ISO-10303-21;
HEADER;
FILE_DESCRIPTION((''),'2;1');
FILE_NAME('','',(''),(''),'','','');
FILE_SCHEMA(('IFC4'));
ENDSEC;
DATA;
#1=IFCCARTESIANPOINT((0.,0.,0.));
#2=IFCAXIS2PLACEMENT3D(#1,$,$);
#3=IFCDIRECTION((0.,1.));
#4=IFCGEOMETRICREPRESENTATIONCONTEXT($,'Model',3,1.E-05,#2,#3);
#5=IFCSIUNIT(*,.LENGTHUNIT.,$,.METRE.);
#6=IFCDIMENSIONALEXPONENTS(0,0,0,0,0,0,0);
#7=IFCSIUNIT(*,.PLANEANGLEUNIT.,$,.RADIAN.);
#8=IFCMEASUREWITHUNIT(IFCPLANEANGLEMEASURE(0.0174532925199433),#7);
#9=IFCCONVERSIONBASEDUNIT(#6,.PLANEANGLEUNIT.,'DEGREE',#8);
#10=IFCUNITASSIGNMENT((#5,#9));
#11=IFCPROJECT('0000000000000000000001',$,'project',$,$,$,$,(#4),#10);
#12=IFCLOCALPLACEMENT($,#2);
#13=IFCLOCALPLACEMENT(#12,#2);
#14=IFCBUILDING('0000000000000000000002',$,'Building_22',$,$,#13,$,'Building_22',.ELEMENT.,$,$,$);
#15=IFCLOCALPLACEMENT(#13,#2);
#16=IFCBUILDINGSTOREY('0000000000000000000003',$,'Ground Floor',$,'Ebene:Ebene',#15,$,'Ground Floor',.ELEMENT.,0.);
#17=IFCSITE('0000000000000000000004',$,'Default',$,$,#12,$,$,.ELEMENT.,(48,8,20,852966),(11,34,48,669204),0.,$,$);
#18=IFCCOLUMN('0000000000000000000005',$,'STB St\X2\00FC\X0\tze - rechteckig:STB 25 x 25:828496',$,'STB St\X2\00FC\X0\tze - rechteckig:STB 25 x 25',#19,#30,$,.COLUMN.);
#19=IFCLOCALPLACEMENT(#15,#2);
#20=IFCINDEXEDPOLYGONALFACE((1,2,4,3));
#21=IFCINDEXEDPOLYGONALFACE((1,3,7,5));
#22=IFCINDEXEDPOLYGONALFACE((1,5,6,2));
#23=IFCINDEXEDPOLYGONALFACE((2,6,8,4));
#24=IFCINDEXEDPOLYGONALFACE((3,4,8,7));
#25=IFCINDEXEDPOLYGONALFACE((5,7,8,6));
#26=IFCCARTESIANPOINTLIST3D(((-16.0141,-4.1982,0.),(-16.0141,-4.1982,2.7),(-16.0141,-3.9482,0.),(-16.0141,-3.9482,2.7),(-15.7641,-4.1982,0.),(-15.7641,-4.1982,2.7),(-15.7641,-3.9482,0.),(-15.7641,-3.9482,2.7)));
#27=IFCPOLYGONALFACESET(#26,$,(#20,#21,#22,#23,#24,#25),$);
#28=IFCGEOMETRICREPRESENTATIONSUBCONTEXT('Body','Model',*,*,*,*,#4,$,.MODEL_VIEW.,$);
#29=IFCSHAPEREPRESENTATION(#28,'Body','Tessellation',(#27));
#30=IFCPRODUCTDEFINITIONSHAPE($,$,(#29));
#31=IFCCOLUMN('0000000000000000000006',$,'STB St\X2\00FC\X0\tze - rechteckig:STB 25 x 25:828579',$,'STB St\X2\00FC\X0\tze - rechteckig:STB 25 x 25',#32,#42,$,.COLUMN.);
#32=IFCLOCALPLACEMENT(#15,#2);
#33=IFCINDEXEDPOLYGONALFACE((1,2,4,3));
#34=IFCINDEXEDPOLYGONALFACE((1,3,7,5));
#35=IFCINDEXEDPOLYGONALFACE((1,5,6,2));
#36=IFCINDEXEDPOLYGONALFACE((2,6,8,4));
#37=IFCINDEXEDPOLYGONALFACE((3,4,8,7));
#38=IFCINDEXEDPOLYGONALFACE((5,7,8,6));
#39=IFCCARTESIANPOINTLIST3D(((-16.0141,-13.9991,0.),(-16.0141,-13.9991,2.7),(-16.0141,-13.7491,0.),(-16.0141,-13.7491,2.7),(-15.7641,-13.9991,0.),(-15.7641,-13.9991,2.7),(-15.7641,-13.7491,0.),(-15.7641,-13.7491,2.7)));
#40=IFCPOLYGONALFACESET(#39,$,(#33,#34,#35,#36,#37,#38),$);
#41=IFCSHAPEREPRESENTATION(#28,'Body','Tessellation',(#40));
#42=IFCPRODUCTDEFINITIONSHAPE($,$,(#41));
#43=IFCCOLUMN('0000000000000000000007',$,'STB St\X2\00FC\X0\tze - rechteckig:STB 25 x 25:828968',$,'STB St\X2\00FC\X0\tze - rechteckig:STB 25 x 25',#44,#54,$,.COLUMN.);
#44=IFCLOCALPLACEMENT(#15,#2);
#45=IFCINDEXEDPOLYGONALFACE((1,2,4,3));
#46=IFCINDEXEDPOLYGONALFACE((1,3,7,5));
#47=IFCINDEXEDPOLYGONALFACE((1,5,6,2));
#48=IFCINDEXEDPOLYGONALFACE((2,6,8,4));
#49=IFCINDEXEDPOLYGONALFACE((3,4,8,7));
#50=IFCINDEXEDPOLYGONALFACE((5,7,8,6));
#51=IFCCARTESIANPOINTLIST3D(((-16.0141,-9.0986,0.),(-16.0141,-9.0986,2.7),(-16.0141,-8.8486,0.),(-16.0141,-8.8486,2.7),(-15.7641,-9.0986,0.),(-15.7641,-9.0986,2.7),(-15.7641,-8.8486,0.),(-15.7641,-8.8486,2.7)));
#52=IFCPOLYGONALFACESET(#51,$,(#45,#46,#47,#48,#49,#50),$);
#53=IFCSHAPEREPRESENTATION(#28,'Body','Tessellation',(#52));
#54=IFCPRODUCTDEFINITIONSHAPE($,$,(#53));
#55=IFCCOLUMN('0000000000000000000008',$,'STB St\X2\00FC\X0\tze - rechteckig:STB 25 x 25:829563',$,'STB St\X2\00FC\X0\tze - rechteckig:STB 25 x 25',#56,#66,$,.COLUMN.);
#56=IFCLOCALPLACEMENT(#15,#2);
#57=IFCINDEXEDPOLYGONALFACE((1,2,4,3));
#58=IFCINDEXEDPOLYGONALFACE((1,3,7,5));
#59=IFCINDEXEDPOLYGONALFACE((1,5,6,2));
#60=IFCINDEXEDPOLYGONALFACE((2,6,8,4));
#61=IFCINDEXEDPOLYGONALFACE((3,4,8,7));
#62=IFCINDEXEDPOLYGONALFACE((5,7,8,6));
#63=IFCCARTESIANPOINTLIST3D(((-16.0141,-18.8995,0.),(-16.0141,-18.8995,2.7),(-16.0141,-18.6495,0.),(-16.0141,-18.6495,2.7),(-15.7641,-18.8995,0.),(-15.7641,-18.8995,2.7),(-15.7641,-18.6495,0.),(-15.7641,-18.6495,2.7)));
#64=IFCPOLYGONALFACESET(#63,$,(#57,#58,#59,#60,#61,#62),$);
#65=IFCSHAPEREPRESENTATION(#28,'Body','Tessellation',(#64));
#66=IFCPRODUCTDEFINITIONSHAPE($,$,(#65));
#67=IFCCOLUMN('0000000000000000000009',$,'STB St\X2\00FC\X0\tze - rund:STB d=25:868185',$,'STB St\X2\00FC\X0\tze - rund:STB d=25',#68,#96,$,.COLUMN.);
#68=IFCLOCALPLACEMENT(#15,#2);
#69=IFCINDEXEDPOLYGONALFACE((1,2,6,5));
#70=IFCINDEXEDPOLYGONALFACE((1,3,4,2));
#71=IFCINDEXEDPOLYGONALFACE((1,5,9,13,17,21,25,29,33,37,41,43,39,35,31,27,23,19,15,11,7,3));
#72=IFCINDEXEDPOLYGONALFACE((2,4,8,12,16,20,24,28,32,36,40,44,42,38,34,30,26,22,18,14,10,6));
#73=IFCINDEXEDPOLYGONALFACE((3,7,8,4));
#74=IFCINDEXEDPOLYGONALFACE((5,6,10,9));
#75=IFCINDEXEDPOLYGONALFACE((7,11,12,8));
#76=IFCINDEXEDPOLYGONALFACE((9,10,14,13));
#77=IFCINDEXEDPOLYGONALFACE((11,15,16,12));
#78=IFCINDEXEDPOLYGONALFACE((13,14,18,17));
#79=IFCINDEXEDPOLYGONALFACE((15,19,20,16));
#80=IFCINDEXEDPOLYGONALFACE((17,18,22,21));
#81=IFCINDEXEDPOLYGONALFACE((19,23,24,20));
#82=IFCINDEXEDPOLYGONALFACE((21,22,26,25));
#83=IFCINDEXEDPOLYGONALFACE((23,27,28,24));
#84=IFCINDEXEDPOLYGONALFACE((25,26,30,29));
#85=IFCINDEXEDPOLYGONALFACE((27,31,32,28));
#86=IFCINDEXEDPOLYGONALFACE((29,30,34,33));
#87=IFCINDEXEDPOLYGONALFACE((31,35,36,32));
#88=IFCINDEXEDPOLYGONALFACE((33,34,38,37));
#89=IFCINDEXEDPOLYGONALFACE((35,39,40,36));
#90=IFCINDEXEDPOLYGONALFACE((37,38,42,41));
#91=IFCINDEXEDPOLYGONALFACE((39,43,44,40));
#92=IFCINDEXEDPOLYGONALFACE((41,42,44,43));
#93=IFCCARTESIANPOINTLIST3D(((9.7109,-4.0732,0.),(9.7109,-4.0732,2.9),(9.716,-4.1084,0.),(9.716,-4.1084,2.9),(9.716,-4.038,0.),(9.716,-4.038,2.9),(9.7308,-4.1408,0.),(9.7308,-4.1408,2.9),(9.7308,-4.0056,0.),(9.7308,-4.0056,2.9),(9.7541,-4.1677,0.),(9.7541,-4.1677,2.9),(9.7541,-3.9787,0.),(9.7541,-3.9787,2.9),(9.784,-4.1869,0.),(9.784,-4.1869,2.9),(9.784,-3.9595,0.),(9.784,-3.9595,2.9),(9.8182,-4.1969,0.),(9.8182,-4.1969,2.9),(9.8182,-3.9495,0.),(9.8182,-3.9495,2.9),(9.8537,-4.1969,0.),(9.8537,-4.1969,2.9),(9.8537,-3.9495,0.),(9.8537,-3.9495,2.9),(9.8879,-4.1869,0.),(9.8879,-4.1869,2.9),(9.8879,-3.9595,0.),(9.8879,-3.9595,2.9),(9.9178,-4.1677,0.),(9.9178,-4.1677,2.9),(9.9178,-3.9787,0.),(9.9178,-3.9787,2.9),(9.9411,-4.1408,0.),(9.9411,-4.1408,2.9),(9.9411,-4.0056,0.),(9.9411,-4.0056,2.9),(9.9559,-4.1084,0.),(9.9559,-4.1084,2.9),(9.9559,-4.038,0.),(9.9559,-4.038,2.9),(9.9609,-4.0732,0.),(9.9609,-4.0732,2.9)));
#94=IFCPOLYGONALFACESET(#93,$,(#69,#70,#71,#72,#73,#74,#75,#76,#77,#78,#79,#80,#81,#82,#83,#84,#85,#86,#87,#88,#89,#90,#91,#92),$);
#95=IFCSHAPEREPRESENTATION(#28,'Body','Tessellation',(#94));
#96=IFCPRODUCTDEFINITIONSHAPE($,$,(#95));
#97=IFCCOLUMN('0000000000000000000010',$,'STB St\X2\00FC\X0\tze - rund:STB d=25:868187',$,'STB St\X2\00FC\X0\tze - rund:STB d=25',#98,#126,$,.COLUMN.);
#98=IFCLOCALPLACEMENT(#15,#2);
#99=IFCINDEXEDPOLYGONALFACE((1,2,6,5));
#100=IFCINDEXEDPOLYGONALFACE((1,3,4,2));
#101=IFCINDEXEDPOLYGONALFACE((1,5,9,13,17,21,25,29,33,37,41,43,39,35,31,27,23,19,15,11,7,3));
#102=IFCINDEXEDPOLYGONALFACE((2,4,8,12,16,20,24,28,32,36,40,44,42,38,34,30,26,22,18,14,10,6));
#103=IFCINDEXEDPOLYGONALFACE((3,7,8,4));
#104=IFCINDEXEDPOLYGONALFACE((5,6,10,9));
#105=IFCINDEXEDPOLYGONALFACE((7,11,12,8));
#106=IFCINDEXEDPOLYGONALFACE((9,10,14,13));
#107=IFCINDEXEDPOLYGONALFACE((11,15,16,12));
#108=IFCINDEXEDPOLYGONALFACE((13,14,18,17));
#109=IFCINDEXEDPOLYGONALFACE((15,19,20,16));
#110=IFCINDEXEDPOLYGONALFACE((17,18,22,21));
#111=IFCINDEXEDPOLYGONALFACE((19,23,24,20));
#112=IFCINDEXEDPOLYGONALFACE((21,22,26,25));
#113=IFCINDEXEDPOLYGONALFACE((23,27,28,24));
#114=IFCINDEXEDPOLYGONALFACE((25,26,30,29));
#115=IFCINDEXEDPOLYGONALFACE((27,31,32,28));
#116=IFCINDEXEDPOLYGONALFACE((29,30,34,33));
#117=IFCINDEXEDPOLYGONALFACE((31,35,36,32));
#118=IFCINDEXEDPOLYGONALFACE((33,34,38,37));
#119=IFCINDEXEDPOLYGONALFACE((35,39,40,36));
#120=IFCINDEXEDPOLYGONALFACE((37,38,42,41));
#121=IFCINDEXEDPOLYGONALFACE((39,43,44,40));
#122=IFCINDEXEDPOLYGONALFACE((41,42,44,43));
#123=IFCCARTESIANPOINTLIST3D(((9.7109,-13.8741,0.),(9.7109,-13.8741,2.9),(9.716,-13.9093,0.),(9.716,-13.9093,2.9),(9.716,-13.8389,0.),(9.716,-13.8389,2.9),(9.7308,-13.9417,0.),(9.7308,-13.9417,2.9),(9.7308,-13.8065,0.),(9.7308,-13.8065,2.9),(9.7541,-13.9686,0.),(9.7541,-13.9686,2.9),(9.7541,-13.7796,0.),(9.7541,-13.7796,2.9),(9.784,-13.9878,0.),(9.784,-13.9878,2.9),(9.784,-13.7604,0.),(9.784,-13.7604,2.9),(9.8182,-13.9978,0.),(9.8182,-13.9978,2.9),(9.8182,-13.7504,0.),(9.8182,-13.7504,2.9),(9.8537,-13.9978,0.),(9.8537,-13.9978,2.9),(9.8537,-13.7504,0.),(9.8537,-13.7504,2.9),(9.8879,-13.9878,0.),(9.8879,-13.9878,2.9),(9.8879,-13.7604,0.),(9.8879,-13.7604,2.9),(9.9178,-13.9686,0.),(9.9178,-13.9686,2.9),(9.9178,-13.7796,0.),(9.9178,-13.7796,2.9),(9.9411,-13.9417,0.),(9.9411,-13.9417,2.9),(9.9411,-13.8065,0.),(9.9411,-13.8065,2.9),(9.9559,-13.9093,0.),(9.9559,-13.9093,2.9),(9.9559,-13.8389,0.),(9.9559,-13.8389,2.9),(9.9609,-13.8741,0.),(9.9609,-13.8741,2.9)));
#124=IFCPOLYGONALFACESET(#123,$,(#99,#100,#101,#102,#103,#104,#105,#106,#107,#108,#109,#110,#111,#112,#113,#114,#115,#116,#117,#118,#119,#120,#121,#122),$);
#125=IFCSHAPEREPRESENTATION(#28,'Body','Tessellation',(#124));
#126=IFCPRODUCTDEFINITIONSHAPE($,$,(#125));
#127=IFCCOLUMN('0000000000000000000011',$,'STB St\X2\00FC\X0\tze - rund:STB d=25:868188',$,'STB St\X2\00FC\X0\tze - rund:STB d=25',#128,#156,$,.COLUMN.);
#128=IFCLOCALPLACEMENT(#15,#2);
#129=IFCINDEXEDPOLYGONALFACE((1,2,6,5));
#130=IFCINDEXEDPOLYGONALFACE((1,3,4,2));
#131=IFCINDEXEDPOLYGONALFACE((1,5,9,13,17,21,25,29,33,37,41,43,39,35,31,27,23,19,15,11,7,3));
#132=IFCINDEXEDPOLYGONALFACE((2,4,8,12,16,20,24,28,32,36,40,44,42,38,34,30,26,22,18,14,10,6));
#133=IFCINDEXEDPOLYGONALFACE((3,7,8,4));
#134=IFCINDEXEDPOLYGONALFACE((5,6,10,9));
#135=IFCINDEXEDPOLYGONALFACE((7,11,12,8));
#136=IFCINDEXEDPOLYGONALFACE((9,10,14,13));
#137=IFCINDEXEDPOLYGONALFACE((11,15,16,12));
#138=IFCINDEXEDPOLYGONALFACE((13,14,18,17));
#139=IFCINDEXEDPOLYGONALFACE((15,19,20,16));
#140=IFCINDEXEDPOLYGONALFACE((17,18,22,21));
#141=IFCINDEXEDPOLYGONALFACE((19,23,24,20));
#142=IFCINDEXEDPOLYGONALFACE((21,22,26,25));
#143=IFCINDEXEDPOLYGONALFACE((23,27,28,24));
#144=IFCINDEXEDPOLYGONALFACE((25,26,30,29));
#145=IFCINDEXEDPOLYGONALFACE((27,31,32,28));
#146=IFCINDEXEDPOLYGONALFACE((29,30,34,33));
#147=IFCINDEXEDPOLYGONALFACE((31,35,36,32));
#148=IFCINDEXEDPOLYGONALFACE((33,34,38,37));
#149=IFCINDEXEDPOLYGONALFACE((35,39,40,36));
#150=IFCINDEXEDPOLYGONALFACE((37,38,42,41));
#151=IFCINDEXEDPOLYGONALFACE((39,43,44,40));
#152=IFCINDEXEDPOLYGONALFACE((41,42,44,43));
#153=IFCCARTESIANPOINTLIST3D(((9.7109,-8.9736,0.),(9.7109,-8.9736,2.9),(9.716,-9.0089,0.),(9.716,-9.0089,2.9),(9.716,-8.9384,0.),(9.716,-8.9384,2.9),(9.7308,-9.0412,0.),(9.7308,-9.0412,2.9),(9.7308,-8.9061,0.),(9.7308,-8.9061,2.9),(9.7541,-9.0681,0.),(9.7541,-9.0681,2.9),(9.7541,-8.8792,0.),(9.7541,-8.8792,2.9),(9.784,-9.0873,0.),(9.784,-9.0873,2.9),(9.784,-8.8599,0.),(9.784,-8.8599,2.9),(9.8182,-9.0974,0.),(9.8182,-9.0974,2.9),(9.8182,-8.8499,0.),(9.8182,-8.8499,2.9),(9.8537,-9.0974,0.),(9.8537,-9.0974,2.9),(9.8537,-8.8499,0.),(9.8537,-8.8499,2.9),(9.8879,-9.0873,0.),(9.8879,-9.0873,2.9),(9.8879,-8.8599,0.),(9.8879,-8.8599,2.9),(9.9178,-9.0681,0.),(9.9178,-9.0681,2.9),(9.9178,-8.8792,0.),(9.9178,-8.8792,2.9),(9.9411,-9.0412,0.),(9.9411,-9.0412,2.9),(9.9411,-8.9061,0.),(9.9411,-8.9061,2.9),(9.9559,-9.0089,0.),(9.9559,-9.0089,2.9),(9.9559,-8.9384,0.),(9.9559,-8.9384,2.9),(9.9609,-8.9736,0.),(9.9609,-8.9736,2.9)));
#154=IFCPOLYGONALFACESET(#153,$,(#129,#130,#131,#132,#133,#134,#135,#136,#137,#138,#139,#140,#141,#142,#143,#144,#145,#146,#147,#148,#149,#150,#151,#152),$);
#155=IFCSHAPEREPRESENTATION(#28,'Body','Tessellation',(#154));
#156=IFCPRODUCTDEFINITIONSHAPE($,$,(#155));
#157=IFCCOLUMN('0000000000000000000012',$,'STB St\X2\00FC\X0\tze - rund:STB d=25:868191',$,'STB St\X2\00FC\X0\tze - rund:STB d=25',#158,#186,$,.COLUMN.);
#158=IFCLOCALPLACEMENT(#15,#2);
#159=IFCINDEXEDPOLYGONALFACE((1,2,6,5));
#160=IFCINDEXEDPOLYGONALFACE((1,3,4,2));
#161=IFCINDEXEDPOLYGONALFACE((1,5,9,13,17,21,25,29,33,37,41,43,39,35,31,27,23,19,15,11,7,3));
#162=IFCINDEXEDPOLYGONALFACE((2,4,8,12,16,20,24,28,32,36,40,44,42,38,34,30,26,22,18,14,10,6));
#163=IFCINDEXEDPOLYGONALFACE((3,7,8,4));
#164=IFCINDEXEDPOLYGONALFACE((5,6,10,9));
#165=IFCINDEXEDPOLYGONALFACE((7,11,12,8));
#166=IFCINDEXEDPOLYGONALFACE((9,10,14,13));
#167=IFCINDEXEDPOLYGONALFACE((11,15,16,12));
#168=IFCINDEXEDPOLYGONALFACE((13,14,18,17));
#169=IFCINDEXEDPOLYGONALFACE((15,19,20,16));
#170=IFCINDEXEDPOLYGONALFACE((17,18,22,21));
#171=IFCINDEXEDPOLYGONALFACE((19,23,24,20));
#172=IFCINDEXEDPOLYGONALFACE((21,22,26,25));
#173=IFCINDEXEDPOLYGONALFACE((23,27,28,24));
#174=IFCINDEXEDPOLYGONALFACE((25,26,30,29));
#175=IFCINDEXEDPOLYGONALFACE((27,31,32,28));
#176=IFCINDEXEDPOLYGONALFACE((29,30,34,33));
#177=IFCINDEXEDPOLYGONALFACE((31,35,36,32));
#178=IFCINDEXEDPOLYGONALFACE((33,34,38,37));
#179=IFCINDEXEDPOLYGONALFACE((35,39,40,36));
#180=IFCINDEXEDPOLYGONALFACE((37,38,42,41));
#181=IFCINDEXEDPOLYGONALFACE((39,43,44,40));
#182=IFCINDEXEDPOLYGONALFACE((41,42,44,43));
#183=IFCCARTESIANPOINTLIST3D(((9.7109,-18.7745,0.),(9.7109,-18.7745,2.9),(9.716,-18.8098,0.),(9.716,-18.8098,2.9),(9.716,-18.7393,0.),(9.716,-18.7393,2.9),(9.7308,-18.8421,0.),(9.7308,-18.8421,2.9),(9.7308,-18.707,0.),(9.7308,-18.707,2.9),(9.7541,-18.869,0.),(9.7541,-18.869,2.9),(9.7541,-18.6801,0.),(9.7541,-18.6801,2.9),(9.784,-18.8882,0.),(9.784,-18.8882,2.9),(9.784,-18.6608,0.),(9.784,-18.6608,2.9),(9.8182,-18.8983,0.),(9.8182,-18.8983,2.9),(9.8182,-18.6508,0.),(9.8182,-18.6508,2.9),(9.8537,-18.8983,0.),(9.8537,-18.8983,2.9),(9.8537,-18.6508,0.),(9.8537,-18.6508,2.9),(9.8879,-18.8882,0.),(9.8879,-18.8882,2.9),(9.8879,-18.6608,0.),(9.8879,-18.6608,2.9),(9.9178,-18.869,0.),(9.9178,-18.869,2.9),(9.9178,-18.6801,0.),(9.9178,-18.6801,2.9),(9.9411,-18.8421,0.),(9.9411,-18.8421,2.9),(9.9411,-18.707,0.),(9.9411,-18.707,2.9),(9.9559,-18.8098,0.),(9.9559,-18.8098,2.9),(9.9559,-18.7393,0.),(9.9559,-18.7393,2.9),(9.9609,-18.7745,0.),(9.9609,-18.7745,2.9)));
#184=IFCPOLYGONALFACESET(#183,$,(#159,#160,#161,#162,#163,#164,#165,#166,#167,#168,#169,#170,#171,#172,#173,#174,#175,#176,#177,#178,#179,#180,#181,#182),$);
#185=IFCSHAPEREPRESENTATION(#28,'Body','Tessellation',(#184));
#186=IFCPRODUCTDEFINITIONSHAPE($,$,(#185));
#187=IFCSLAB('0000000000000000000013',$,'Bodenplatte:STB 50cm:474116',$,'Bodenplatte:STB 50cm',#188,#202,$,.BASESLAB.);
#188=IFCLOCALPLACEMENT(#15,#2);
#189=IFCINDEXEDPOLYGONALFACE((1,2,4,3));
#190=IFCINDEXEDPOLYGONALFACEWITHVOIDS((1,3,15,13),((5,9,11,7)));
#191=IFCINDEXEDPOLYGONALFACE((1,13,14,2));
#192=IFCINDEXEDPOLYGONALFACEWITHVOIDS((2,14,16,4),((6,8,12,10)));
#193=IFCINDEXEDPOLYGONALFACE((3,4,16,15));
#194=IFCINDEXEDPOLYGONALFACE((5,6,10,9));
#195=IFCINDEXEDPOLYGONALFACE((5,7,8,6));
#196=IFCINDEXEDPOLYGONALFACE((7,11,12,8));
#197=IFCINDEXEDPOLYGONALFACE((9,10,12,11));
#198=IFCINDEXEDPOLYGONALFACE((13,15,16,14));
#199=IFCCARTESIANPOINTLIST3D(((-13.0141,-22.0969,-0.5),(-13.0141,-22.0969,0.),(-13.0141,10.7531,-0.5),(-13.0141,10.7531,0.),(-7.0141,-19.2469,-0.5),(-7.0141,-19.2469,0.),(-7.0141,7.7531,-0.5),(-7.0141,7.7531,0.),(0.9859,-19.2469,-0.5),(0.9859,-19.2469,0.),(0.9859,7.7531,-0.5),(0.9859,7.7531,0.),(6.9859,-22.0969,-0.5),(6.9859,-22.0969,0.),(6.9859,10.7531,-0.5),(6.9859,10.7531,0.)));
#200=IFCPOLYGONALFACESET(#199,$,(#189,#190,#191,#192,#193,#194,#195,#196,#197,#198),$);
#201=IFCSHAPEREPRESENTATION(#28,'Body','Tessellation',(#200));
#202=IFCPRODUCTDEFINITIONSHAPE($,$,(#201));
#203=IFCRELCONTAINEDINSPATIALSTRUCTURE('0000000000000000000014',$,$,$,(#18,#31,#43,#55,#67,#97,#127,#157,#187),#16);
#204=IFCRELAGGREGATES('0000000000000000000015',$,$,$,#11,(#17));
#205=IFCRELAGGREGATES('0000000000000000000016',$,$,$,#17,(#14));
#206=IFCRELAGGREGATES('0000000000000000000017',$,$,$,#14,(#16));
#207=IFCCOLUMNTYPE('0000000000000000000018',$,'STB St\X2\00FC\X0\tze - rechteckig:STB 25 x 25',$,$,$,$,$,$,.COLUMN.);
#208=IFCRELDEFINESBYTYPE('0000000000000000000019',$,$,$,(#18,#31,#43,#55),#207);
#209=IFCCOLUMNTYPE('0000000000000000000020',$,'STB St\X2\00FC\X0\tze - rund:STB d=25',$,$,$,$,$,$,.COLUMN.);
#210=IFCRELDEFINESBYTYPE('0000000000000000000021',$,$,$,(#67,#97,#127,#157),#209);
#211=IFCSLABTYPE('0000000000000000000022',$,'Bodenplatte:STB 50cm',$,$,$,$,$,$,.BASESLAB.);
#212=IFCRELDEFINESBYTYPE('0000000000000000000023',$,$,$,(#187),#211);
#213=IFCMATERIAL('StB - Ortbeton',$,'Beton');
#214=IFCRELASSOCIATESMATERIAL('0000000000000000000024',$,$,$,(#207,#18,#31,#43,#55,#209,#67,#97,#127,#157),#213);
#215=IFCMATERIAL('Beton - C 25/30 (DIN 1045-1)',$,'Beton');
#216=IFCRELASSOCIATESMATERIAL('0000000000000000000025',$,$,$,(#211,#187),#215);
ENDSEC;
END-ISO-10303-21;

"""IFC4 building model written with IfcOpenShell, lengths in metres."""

from ifc_helpers import new_model, entity, si_unit, converted_unit, direction, frame, origin, place, context, subcontext, project, spatial, arc, indexed_curve, outline, extrude, source, transform, mapped, material, type_object, type_shapes, element, save


model = new_model("IFC4")

# Units and contexts
model_context = context("Model", 3, precision=1e-05, world=origin(), true_north=direction((0.0, 1.0)))
body_context = subcontext(model_context, "Body", "Model", "MODEL_VIEW")
ifc_project = project(units=[si_unit("LENGTHUNIT", "METRE"), converted_unit("PLANEANGLEUNIT", "DEGREE", entity("IfcPlaneAngleMeasure", 0.0174532925199433), si_unit("PLANEANGLEUNIT", "RADIAN"), dimensions=[0, 0, 0, 0, 0, 0, 0])], contexts=[model_context])

# Site, building, storey
site_placement = place(None, origin())
site = spatial("IfcSite", under=ifc_project, at=site_placement, Name="Default", CompositionType="ELEMENT", RefLatitude=(48, 8, 20, 852966), RefLongitude=(11, 34, 48, 669204), RefElevation=0.0)
building_placement = place(site_placement, origin())
building = spatial("IfcBuilding", under=site, at=building_placement, Name="Building_22", LongName="Building_22", CompositionType="ELEMENT")
storey_placement = place(building_placement, origin())
storey = spatial("IfcBuildingStorey", under=building, at=storey_placement, Name="Ground Floor", ObjectType="Ebene:Ebene", LongName="Ground Floor", CompositionType="ELEMENT", Elevation=0.0)

# Columns
ifc_material_1 = material(Name="StB - Ortbeton", Category="Beton")
column_type_1 = type_object("IfcColumnType", Name="STB Stütze - rechteckig:STB 25 x 25", PredefinedType="COLUMN", material=ifc_material_1)
shared_shape_1 = source(origin(), body_context, "Body", "SweptSolid", [
    extrude(outline(indexed_curve([(-0.125, -0.125), (0.125, -0.125), (0.125, 0.125), (-0.125, 0.125), (-0.125, -0.125)], self_intersect=False)), frame((0.0, 0.0, 0.0), z_axis=(0.0, 0.0, 1.0), x_axis=(-1.0, 0.0, 0.0)), (0.0, 0.0, 1.0), 2.7),
])
type_shapes(column_type_1, [shared_shape_1])
for number, where, name in (
    (1, (-15.8891, -4.0732, 0.0), "STB Stütze - rechteckig:STB 25 x 25:828496"),
    (2, (-15.8891, -13.8741, 0.0), "STB Stütze - rechteckig:STB 25 x 25:828579"),
    (3, (-15.8891, -8.9736, 0.0), "STB Stütze - rechteckig:STB 25 x 25:828968"),
    (4, (-15.8891, -18.7745, 0.0), "STB Stütze - rechteckig:STB 25 x 25:829563"),
):
    element("IfcColumn", number, at=place(storey_placement, frame(where)), inside=storey, type_object=column_type_1, material=ifc_material_1, Name=name, ObjectType="STB Stütze - rechteckig:STB 25 x 25", PredefinedType="COLUMN", context=body_context, shape_type="MappedRepresentation", body=[
        mapped(shared_shape_1, transform((0.0, 0.0, 0.0), scale=1.0)),
    ])
column_type_2 = type_object("IfcColumnType", Name="STB Stütze - rund:STB d=25", PredefinedType="COLUMN", material=ifc_material_1)
shared_shape_2 = source(origin(), body_context, "Body", "SweptSolid", [
    extrude(outline(indexed_curve([(-0.125, 0.0), (0.0, -0.125), (0.125, 0.0), (0.0, 0.125)], segments=[arc(1, 2, 3), arc(3, 4, 1)], self_intersect=False)), origin(), (0.0, 0.0, 1.0), 2.9),
])
type_shapes(column_type_2, [shared_shape_2])
for number, where, z_axis, x_axis, name in (
    (5, (9.8359, -4.0732, 0.0), (0.0, 0.0, 1.0), (-1.0, 0.0, 0.0), "STB Stütze - rund:STB d=25:868185"),
    (6, (9.8359, -13.8741, 0.0), (0.0, 0.0, 1.0), (-1.0, 0.0, 0.0), "STB Stütze - rund:STB d=25:868187"),
    (7, (9.8359, -8.9736, 0.0), (0.0, 0.0, 1.0), (-1.0, 0.0, 0.0), "STB Stütze - rund:STB d=25:868188"),
    (8, (9.8359, -18.7745, 0.0), (0.0, 0.0, 1.0), (-1.0, 0.0, 0.0), "STB Stütze - rund:STB d=25:868191"),
):
    element("IfcColumn", number, at=place(storey_placement, frame(where, z_axis=z_axis, x_axis=x_axis)), inside=storey, type_object=column_type_2, material=ifc_material_1, Name=name, ObjectType="STB Stütze - rund:STB d=25", PredefinedType="COLUMN", context=body_context, shape_type="MappedRepresentation", body=[
        mapped(shared_shape_2, transform((0.0, 0.0, 0.0), scale=1.0)),
    ])

# Slab, opening
ifc_material_2 = material(Name="Beton - C 25/30 (DIN 1045-1)", Category="Beton")
slab_type_1 = type_object("IfcSlabType", Name="Bodenplatte:STB 50cm", PredefinedType="BASESLAB", material=ifc_material_2)
slab_1_placement = place(storey_placement, origin())
slab_1 = element("IfcSlab", 9, at=slab_1_placement, inside=storey, type_object=slab_type_1, material=ifc_material_2, Name="Bodenplatte:STB 50cm:474116", ObjectType="Bodenplatte:STB 50cm", PredefinedType="BASESLAB", context=body_context, shape_type="SweptSolid", body=[
    extrude(outline(indexed_curve([(-10.0, -16.425), (10.0, -16.425), (10.0, 16.425), (-10.0, 16.425), (-10.0, -16.425)], self_intersect=False), holes=[indexed_curve([(-4.0, -13.425), (-4.0, 13.575), (4.0, 13.575), (4.0, -13.425), (-4.0, -13.425)], self_intersect=False)]), frame((-3.0141, -5.6719, -0.5), z_axis=(0.0, 0.0, 1.0), x_axis=(-1.0, 0.0, 0.0)), (0.0, 0.0, 1.0), 0.5),
])
opening_placement = place(slab_1_placement, origin())
element("IfcOpeningElement", 10, at=opening_placement, cuts=slab_1, PredefinedType="OPENING", context=body_context, shape_type="SweptSolid", body=[
    extrude(outline(indexed_curve([(-13.5, -4.0), (13.5, -4.0), (13.5, 4.0), (-13.5, 4.0), (-13.5, -4.0)], self_intersect=False)), frame((-3.0141, -5.7469, 0.0), z_axis=(0.0, 0.0, -1.0), x_axis=(0.0, -1.0, 0.0)), (0.0, 0.0, 1.0), 32.85),
])

save(model, "model.ifc")
